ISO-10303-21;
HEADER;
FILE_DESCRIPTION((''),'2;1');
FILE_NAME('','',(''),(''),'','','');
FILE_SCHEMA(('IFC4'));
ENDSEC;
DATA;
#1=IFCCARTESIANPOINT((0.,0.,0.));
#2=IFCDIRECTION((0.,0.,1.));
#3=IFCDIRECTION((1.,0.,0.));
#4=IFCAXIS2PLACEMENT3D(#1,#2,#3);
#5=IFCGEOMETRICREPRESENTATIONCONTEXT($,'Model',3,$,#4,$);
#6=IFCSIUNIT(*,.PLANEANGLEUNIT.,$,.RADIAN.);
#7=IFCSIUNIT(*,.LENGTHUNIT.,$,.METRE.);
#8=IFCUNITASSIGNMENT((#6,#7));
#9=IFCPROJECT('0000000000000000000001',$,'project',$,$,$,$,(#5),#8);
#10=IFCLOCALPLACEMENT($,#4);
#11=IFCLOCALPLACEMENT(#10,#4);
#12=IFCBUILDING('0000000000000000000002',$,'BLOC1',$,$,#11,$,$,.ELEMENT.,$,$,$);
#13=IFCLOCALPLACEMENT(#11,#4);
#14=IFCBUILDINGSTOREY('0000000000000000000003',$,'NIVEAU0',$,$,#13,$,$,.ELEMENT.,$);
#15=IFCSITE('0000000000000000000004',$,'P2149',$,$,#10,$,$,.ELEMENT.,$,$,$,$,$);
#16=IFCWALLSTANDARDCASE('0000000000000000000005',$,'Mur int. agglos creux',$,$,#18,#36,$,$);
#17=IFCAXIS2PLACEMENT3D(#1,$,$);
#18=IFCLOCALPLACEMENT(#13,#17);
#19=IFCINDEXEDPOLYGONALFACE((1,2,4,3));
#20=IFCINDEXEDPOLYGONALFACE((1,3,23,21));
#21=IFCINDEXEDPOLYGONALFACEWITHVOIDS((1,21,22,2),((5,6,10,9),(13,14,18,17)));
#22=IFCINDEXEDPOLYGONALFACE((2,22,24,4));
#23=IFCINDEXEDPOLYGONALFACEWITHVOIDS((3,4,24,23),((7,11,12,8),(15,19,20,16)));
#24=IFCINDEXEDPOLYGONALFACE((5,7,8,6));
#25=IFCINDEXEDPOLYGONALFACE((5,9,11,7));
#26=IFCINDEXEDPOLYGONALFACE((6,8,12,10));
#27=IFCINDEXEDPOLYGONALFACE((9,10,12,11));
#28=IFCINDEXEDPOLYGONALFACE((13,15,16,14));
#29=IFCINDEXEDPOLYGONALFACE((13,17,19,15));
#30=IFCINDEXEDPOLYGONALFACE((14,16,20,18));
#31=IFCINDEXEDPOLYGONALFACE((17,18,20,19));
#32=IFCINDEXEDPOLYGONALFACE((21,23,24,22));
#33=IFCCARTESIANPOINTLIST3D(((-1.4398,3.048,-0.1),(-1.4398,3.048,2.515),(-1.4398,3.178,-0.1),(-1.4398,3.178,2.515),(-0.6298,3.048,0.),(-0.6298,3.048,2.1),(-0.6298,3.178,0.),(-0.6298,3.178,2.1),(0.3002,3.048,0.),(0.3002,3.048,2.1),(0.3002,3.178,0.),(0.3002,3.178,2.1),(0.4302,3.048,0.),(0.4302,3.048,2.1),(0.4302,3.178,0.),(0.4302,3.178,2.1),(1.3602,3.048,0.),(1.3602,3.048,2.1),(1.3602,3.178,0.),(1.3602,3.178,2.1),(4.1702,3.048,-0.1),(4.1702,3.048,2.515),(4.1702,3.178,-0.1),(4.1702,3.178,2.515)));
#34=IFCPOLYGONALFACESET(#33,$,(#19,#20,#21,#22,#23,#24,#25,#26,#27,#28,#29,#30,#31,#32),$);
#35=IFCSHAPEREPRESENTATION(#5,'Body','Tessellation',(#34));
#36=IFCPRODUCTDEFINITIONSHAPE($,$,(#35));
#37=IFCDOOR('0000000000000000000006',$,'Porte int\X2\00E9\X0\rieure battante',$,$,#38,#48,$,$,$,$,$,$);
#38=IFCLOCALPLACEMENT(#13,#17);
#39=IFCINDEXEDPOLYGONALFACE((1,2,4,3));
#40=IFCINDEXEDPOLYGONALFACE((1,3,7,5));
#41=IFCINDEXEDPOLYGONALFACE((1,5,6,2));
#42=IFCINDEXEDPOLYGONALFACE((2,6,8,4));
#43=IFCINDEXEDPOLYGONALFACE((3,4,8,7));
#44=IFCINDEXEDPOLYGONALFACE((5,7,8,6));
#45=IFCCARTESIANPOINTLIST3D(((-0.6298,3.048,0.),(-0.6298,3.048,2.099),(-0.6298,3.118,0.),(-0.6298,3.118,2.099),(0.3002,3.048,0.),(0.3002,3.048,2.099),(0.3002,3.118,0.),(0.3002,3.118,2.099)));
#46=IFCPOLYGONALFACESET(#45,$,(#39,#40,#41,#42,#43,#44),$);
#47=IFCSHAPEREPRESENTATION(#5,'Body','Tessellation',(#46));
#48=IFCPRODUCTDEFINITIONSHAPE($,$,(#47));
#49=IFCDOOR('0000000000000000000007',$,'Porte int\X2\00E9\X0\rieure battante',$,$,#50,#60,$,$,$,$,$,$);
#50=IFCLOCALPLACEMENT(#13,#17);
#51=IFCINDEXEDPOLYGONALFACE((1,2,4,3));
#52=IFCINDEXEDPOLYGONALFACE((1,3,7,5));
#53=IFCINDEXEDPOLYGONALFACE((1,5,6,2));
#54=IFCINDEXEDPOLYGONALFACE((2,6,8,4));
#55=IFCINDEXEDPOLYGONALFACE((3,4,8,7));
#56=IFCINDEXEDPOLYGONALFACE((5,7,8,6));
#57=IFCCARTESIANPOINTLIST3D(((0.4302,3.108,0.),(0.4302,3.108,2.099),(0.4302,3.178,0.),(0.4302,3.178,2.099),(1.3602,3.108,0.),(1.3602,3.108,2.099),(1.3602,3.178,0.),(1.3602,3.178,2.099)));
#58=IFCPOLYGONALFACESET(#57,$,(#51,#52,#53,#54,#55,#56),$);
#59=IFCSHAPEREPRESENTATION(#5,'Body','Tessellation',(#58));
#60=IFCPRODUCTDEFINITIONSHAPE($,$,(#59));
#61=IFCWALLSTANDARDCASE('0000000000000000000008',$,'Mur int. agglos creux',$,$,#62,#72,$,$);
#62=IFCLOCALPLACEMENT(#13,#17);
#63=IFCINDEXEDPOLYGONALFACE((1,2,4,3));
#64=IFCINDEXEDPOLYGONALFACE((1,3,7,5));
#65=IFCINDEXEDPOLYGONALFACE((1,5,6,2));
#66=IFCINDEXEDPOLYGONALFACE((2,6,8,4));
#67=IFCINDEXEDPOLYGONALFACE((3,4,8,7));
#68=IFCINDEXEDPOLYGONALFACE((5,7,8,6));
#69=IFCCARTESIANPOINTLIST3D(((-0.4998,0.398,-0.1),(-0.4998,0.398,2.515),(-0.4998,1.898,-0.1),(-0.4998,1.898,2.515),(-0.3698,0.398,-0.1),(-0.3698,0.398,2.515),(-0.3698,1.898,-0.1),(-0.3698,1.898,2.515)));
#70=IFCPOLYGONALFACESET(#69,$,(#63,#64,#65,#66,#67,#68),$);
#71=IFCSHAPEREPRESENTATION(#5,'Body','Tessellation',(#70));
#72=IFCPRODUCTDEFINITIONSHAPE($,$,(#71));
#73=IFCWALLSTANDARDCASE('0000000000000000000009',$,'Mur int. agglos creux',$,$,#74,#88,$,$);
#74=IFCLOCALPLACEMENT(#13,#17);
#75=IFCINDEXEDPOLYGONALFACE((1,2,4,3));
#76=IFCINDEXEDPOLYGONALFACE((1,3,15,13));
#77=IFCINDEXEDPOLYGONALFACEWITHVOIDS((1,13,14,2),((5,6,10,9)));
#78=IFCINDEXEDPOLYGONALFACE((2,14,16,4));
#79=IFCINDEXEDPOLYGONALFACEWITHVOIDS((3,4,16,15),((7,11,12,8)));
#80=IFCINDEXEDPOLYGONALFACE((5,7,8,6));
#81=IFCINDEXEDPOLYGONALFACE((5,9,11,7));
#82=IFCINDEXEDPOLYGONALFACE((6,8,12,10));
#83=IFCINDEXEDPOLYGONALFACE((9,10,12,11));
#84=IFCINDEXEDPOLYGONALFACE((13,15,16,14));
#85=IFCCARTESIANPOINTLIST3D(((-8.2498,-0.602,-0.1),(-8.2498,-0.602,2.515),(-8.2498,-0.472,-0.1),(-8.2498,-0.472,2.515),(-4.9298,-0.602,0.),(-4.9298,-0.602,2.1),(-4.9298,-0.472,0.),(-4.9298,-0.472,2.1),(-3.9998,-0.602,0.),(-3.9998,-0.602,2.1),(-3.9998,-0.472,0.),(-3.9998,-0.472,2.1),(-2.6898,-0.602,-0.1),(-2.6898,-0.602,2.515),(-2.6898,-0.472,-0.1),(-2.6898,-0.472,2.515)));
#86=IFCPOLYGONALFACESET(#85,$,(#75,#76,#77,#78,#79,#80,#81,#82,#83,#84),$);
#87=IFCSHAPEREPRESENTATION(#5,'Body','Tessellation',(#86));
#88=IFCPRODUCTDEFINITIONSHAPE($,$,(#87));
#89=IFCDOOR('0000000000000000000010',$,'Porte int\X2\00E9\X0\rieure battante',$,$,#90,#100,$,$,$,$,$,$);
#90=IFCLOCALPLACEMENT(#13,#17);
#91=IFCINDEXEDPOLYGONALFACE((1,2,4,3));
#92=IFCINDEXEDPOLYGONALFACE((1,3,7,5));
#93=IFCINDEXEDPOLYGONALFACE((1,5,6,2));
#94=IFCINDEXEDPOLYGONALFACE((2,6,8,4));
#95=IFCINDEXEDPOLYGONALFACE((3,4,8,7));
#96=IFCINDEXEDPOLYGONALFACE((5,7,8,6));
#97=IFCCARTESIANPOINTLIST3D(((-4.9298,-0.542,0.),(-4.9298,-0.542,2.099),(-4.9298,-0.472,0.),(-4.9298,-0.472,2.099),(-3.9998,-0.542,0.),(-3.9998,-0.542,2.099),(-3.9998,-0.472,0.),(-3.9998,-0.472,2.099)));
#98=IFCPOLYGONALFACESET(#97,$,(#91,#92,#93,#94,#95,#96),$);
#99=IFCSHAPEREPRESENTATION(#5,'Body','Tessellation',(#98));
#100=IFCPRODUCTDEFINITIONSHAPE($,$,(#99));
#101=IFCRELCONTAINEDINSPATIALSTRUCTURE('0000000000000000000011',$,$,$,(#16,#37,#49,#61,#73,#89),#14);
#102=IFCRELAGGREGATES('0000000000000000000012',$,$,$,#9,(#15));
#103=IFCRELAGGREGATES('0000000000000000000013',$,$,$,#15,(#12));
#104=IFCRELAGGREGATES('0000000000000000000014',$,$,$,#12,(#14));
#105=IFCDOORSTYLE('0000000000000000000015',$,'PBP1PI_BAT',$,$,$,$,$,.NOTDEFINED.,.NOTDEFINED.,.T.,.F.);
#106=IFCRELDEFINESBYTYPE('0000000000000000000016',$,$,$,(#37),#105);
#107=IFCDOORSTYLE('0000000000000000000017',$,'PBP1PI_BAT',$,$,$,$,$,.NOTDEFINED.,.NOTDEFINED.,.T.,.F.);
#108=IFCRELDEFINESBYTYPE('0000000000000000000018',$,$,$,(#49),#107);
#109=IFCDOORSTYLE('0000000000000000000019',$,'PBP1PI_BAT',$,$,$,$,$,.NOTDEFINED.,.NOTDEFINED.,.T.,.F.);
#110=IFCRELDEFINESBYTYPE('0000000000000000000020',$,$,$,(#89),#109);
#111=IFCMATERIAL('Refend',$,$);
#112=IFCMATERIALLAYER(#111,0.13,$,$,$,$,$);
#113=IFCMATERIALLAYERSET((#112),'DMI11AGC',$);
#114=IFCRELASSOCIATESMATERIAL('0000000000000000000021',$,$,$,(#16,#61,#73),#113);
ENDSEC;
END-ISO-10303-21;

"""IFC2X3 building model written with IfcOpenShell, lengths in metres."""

from ifc_helpers import new_model, si_unit, point, frame, frame_2d, origin_with_axes, place, context, project, spatial, line_curve, trimmed, segment, composite_curve, rectangle, outline, extrude, material, layer, layer_set, layer_usage, type_object, element, fill, save


model = new_model("IFC2X3")

# Units and contexts
model_context = context("Model", 3, world=origin_with_axes())
ifc_project = project(units=[si_unit("PLANEANGLEUNIT", "RADIAN"), si_unit("LENGTHUNIT", "METRE")], contexts=[model_context])

# Site, building, storey
site_placement = place(None, origin_with_axes())
site = spatial("IfcSite", under=ifc_project, at=site_placement, Name="P2149", CompositionType="ELEMENT")
building_placement = place(site_placement, origin_with_axes())
building = spatial("IfcBuilding", under=site, at=building_placement, Name="BLOC1", CompositionType="ELEMENT")
storey_placement = place(building_placement, origin_with_axes())
storey = spatial("IfcBuildingStorey", under=building, at=storey_placement, Name="NIVEAU0", CompositionType="ELEMENT")

# Shared definitions
ifc_material_1 = material(Name="Refend")
ifc_layer_1 = layer(ifc_material_1, 0.13)
ifc_layer_set_1 = layer_set([ifc_layer_1], Name="DMI11AGC")
ifc_layer_usage_1 = layer_usage(ifc_layer_set_1, "AXIS2", "POSITIVE", 0.0)

# Wall, openings, doors
wall_1_placement = place(storey_placement, frame((-1.4398, 3.048, -0.1), z_axis=(0.0, 0.0, 1.0), x_axis=(1.0, 0.0, 0.0)))
wall_1 = element("IfcWallStandardCase", 1, at=wall_1_placement, inside=storey, material=ifc_layer_usage_1, Name="Mur int. agglos creux", context=model_context, shape_type="SweptSolid", body=[
    extrude(outline(composite_curve([segment(trimmed(line_curve((0.0, 0.0), (1.0, 0.0), 5.61), [point((0.0, 0.0))], [point((5.61, 0.0))], True, "CARTESIAN"), True, "CONTINUOUS"), segment(trimmed(line_curve((5.61, 0.0), (0.0, 1.0), 0.13), [point((5.61, 0.0))], [point((5.61, 0.13))], True, "CARTESIAN"), True, "CONTINUOUS"), segment(trimmed(line_curve((5.61, 0.13), (-1.0, 0.0), 5.61), [point((5.61, 0.13))], [point((0.0, 0.13))], True, "CARTESIAN"), True, "CONTINUOUS"), segment(trimmed(line_curve((0.0, 0.13), (0.0, -1.0), 0.13), [point((0.0, 0.13))], [point((0.0, 0.0))], True, "CARTESIAN"), True, "CONTINUOUS")], self_intersect=False)), origin_with_axes(), (0.0, 0.0, 1.0), 2.615),
])
opening_1_placement = place(wall_1_placement, frame((0.81, 0.0, 0.1), z_axis=(0.0, -1.0, 0.0), x_axis=(1.0, 0.0, 0.0)))
opening_1 = element("IfcOpeningElement", 2, at=opening_1_placement, cuts=wall_1, context=model_context, shape_type="SweptSolid", body=[
    extrude(rectangle(XDim=0.93, YDim=2.1, at=frame_2d((0.465, 1.05), x_axis=(1.0, 0.0))), origin_with_axes(), (0.0, 0.0, -1.0), 0.13),
])
opening_2_placement = place(wall_1_placement, frame((2.8, 0.13, 0.1), z_axis=(0.0, 1.0, 0.0), x_axis=(-1.0, 0.0, 0.0)))
opening_2 = element("IfcOpeningElement", 3, at=opening_2_placement, cuts=wall_1, context=model_context, shape_type="SweptSolid", body=[
    extrude(rectangle(XDim=0.93, YDim=2.1, at=frame_2d((0.465, 1.05), x_axis=(1.0, 0.0))), origin_with_axes(), (0.0, 0.0, -1.0), 0.13),
])
door_style_1 = type_object("IfcDoorStyle", Name="PBP1PI_BAT", ConstructionType="NOTDEFINED", OperationType="NOTDEFINED", ParameterTakesPrecedence=True, Sizeable=False)
door_1_placement = place(opening_1_placement, origin_with_axes())
door_1 = element("IfcDoor", 4, at=door_1_placement, inside=storey, type_object=door_style_1, Name="Porte intérieure battante", context=model_context, shape_type="SweptSolid", body=[
    extrude(rectangle(XDim=0.93, YDim=2.099, at=frame_2d((0.465, 1.0495), x_axis=(1.0, 0.0))), origin_with_axes(), (0.0, 0.0, -1.0), 0.07),
])
fill(opening_1, door_1)
door_style_2 = type_object("IfcDoorStyle", Name="PBP1PI_BAT", ConstructionType="NOTDEFINED", OperationType="NOTDEFINED", ParameterTakesPrecedence=True, Sizeable=False)
door_2_placement = place(opening_2_placement, origin_with_axes())
door_2 = element("IfcDoor", 5, at=door_2_placement, inside=storey, type_object=door_style_2, Name="Porte intérieure battante", context=model_context, shape_type="SweptSolid", body=[
    extrude(rectangle(XDim=0.93, YDim=2.099, at=frame_2d((0.465, 1.0495), x_axis=(1.0, 0.0))), origin_with_axes(), (0.0, 0.0, -1.0), 0.07),
])
fill(opening_2, door_2)

# Wall
wall_2_placement = place(storey_placement, frame((-0.4998, 1.898, -0.1), z_axis=(0.0, 0.0, 1.0), x_axis=(0.0, -1.0, 0.0)))
element("IfcWallStandardCase", 6, at=wall_2_placement, inside=storey, material=ifc_layer_usage_1, Name="Mur int. agglos creux", context=model_context, shape_type="SweptSolid", body=[
    extrude(outline(composite_curve([segment(trimmed(line_curve((0.0, 0.0), (1.0, 0.0), 1.5), [point((0.0, 0.0))], [point((1.5, 0.0))], True, "CARTESIAN"), True, "CONTINUOUS"), segment(trimmed(line_curve((1.5, 0.0), (0.0, 1.0), 0.13), [point((1.5, 0.0))], [point((1.5, 0.13))], True, "CARTESIAN"), True, "CONTINUOUS"), segment(trimmed(line_curve((1.5, 0.13), (-1.0, 0.0), 1.5), [point((1.5, 0.13))], [point((0.0, 0.13))], True, "CARTESIAN"), True, "CONTINUOUS"), segment(trimmed(line_curve((0.0, 0.13), (0.0, -1.0), 0.13), [point((0.0, 0.13))], [point((0.0, 0.0))], True, "CARTESIAN"), True, "CONTINUOUS")], self_intersect=False)), origin_with_axes(), (0.0, 0.0, 1.0), 2.615),
])

# Wall, opening, door
wall_3_placement = place(storey_placement, frame((-2.6898, -0.472, -0.1), z_axis=(0.0, 0.0, 1.0), x_axis=(-1.0, 0.0, 0.0)))
wall_3 = element("IfcWallStandardCase", 7, at=wall_3_placement, inside=storey, material=ifc_layer_usage_1, Name="Mur int. agglos creux", context=model_context, shape_type="SweptSolid", body=[
    extrude(outline(composite_curve([segment(trimmed(line_curve((0.0, 0.0), (1.0, 0.0), 5.56), [point((0.0, 0.0))], [point((5.56, 0.0))], True, "CARTESIAN"), True, "CONTINUOUS"), segment(trimmed(line_curve((5.56, 0.0), (0.0, 1.0), 0.13), [point((5.56, 0.0))], [point((5.56, 0.13))], True, "CARTESIAN"), True, "CONTINUOUS"), segment(trimmed(line_curve((5.56, 0.13), (-1.0, 0.0), 5.56), [point((5.56, 0.13))], [point((0.0, 0.13))], True, "CARTESIAN"), True, "CONTINUOUS"), segment(trimmed(line_curve((0.0, 0.13), (0.0, -1.0), 0.13), [point((0.0, 0.13))], [point((0.0, 0.0))], True, "CARTESIAN"), True, "CONTINUOUS")], self_intersect=False)), origin_with_axes(), (0.0, 0.0, 1.0), 2.615),
])
opening_3_placement = place(wall_3_placement, frame((1.31, 0.0, 0.1), z_axis=(0.0, -1.0, 0.0), x_axis=(1.0, 0.0, 0.0)))
opening_3 = element("IfcOpeningElement", 8, at=opening_3_placement, cuts=wall_3, context=model_context, shape_type="SweptSolid", body=[
    extrude(rectangle(XDim=0.93, YDim=2.1, at=frame_2d((0.465, 1.05), x_axis=(1.0, 0.0))), origin_with_axes(), (0.0, 0.0, -1.0), 0.13),
])
door_style_3 = type_object("IfcDoorStyle", Name="PBP1PI_BAT", ConstructionType="NOTDEFINED", OperationType="NOTDEFINED", ParameterTakesPrecedence=True, Sizeable=False)
door_3_placement = place(opening_3_placement, origin_with_axes())
door_3 = element("IfcDoor", 9, at=door_3_placement, inside=storey, type_object=door_style_3, Name="Porte intérieure battante", context=model_context, shape_type="SweptSolid", body=[
    extrude(rectangle(XDim=0.93, YDim=2.099, at=frame_2d((0.465, 1.0495), x_axis=(1.0, 0.0))), origin_with_axes(), (0.0, 0.0, -1.0), 0.07),
])
fill(opening_3, door_3)

save(model, "model.ifc")
